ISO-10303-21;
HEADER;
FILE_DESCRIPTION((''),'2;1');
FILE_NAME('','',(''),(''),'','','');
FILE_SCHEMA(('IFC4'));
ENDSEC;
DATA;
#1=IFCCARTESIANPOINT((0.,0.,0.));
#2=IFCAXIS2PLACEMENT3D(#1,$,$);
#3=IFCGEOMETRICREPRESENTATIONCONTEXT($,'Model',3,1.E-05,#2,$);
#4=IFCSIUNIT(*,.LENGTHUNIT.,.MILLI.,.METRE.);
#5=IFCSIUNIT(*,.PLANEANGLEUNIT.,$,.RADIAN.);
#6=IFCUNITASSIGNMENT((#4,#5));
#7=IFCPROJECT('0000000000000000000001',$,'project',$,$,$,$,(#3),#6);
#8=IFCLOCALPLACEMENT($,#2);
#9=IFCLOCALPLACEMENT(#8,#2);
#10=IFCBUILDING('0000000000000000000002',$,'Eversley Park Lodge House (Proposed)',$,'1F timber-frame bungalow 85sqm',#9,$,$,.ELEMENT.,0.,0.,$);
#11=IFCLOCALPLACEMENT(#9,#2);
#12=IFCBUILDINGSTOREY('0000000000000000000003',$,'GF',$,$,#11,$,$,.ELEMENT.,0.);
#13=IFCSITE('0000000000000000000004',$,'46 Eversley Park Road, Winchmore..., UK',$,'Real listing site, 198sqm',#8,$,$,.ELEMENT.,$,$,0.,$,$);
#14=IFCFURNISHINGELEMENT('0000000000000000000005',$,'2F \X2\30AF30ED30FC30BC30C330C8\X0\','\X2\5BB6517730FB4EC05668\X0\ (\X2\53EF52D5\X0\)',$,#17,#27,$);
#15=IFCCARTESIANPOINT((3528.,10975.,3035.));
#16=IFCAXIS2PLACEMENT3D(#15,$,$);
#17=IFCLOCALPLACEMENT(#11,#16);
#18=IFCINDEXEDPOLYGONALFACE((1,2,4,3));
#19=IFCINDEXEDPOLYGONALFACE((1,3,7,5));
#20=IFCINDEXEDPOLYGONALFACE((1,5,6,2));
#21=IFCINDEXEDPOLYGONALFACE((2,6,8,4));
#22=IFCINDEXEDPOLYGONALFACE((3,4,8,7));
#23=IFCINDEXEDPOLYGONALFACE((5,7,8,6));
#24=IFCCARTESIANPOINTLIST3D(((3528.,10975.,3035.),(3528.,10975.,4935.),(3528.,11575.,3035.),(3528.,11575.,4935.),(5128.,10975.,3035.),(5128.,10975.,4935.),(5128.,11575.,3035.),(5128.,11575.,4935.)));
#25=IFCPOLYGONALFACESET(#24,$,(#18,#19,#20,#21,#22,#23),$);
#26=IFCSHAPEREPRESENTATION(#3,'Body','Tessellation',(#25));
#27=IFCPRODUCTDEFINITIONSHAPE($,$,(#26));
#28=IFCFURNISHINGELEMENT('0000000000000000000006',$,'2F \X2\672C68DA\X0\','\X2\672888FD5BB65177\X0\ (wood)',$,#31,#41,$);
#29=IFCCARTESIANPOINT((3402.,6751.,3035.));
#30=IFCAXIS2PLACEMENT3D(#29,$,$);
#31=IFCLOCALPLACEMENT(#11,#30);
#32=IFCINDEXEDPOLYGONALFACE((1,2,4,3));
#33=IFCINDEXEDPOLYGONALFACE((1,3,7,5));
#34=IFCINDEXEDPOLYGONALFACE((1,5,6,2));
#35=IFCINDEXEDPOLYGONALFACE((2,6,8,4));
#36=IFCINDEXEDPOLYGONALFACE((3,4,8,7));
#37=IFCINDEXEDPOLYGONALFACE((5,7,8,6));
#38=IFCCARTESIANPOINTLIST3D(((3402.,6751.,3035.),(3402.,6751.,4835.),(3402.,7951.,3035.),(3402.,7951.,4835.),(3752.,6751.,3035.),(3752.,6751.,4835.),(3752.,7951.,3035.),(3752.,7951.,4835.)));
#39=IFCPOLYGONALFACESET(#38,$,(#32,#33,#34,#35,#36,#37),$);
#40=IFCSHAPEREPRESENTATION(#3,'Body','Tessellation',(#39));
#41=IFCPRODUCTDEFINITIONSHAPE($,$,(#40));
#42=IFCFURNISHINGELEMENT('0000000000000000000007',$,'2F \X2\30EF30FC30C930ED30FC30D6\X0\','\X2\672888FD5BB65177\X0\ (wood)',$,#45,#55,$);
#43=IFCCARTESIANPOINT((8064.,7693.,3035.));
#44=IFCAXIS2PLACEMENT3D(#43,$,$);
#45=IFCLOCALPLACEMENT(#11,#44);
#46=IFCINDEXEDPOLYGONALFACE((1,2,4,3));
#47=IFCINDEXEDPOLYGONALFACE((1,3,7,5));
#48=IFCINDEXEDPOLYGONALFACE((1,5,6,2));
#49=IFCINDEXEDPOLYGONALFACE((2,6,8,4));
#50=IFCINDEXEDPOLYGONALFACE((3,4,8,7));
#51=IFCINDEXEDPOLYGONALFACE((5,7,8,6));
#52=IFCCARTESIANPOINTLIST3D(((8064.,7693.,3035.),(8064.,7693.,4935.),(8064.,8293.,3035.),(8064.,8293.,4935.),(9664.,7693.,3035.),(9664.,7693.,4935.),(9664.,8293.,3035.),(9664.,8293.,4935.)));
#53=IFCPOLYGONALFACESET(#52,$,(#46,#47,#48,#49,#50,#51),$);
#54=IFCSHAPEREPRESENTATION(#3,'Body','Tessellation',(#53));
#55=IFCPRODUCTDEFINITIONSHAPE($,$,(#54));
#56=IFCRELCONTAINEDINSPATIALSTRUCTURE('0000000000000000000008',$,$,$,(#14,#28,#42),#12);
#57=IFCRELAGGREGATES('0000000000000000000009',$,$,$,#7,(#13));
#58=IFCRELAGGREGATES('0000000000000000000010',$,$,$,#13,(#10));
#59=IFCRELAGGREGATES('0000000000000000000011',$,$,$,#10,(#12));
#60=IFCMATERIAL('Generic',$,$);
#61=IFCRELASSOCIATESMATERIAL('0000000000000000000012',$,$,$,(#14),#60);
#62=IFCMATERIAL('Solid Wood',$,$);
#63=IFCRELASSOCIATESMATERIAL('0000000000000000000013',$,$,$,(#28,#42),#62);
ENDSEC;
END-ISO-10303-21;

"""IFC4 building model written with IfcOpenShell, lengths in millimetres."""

from ifc_helpers import new_model, si_unit, frame, frame_2d, origin, place, context, project, spatial, rectangle, extrude, material, element, save


model = new_model("IFC4")

# Units and contexts
model_context = context("Model", 3, precision=1e-05, world=origin())
ifc_project = project(units=[si_unit("LENGTHUNIT", "METRE", prefix="MILLI"), si_unit("PLANEANGLEUNIT", "RADIAN")], contexts=[model_context])

# Site, building, storey
site_placement = place(None, origin())
site = spatial("IfcSite", under=ifc_project, at=site_placement, Name="46 Eversley Park Road, Winchmore..., UK", ObjectType="Real listing site, 198sqm", CompositionType="ELEMENT", RefElevation=0.0)
building_placement = place(site_placement, origin())
building = spatial("IfcBuilding", under=site, at=building_placement, Name="Eversley Park Lodge House (Proposed)", ObjectType="1F timber-frame bungalow 85sqm", CompositionType="ELEMENT", ElevationOfRefHeight=0.0, ElevationOfTerrain=0.0)
storey_placement = place(building_placement, origin())
storey = spatial("IfcBuildingStorey", under=building, at=storey_placement, Name="GF", CompositionType="ELEMENT", Elevation=0.0)

# Shared definitions
ifc_material_1 = material(Name="Solid Wood")

# Shared definitions
ifc_material_2 = material(Name="Generic")

# Furnishing elements
furnishing_1_placement = place(storey_placement, frame((3528.0, 10975.0, 3035.0)))
element("IfcFurnishingElement", 1, at=furnishing_1_placement, inside=storey, material=ifc_material_2, Name="2F クローゼット", Description="家具・什器 (可動)", context=model_context, shape_type="SweptSolid", body=[
    extrude(rectangle(XDim=1600.0, YDim=600.0, at=frame_2d((800.0, 300.0))), frame((3528.0, 10975.0, 3035.0)), (0.0, 0.0, 1.0), 1900.0),
])
furnishing_2_placement = place(storey_placement, frame((3402.0, 6751.0, 3035.0)))
element("IfcFurnishingElement", 2, at=furnishing_2_placement, inside=storey, material=ifc_material_1, Name="2F 本棚", Description="木製家具 (wood)", context=model_context, shape_type="SweptSolid", body=[
    extrude(rectangle(XDim=350.0, YDim=1200.0, at=frame_2d((175.0, 600.0))), frame((3402.0, 6751.0, 3035.0)), (0.0, 0.0, 1.0), 1800.0),
])
furnishing_3_placement = place(storey_placement, frame((8064.0, 7693.0, 3035.0)))
element("IfcFurnishingElement", 3, at=furnishing_3_placement, inside=storey, material=ifc_material_1, Name="2F ワードローブ", Description="木製家具 (wood)", context=model_context, shape_type="SweptSolid", body=[
    extrude(rectangle(XDim=1600.0, YDim=600.0, at=frame_2d((800.0, 300.0))), frame((8064.0, 7693.0, 3035.0)), (0.0, 0.0, 1.0), 1900.0),
])

save(model, "model.ifc")
